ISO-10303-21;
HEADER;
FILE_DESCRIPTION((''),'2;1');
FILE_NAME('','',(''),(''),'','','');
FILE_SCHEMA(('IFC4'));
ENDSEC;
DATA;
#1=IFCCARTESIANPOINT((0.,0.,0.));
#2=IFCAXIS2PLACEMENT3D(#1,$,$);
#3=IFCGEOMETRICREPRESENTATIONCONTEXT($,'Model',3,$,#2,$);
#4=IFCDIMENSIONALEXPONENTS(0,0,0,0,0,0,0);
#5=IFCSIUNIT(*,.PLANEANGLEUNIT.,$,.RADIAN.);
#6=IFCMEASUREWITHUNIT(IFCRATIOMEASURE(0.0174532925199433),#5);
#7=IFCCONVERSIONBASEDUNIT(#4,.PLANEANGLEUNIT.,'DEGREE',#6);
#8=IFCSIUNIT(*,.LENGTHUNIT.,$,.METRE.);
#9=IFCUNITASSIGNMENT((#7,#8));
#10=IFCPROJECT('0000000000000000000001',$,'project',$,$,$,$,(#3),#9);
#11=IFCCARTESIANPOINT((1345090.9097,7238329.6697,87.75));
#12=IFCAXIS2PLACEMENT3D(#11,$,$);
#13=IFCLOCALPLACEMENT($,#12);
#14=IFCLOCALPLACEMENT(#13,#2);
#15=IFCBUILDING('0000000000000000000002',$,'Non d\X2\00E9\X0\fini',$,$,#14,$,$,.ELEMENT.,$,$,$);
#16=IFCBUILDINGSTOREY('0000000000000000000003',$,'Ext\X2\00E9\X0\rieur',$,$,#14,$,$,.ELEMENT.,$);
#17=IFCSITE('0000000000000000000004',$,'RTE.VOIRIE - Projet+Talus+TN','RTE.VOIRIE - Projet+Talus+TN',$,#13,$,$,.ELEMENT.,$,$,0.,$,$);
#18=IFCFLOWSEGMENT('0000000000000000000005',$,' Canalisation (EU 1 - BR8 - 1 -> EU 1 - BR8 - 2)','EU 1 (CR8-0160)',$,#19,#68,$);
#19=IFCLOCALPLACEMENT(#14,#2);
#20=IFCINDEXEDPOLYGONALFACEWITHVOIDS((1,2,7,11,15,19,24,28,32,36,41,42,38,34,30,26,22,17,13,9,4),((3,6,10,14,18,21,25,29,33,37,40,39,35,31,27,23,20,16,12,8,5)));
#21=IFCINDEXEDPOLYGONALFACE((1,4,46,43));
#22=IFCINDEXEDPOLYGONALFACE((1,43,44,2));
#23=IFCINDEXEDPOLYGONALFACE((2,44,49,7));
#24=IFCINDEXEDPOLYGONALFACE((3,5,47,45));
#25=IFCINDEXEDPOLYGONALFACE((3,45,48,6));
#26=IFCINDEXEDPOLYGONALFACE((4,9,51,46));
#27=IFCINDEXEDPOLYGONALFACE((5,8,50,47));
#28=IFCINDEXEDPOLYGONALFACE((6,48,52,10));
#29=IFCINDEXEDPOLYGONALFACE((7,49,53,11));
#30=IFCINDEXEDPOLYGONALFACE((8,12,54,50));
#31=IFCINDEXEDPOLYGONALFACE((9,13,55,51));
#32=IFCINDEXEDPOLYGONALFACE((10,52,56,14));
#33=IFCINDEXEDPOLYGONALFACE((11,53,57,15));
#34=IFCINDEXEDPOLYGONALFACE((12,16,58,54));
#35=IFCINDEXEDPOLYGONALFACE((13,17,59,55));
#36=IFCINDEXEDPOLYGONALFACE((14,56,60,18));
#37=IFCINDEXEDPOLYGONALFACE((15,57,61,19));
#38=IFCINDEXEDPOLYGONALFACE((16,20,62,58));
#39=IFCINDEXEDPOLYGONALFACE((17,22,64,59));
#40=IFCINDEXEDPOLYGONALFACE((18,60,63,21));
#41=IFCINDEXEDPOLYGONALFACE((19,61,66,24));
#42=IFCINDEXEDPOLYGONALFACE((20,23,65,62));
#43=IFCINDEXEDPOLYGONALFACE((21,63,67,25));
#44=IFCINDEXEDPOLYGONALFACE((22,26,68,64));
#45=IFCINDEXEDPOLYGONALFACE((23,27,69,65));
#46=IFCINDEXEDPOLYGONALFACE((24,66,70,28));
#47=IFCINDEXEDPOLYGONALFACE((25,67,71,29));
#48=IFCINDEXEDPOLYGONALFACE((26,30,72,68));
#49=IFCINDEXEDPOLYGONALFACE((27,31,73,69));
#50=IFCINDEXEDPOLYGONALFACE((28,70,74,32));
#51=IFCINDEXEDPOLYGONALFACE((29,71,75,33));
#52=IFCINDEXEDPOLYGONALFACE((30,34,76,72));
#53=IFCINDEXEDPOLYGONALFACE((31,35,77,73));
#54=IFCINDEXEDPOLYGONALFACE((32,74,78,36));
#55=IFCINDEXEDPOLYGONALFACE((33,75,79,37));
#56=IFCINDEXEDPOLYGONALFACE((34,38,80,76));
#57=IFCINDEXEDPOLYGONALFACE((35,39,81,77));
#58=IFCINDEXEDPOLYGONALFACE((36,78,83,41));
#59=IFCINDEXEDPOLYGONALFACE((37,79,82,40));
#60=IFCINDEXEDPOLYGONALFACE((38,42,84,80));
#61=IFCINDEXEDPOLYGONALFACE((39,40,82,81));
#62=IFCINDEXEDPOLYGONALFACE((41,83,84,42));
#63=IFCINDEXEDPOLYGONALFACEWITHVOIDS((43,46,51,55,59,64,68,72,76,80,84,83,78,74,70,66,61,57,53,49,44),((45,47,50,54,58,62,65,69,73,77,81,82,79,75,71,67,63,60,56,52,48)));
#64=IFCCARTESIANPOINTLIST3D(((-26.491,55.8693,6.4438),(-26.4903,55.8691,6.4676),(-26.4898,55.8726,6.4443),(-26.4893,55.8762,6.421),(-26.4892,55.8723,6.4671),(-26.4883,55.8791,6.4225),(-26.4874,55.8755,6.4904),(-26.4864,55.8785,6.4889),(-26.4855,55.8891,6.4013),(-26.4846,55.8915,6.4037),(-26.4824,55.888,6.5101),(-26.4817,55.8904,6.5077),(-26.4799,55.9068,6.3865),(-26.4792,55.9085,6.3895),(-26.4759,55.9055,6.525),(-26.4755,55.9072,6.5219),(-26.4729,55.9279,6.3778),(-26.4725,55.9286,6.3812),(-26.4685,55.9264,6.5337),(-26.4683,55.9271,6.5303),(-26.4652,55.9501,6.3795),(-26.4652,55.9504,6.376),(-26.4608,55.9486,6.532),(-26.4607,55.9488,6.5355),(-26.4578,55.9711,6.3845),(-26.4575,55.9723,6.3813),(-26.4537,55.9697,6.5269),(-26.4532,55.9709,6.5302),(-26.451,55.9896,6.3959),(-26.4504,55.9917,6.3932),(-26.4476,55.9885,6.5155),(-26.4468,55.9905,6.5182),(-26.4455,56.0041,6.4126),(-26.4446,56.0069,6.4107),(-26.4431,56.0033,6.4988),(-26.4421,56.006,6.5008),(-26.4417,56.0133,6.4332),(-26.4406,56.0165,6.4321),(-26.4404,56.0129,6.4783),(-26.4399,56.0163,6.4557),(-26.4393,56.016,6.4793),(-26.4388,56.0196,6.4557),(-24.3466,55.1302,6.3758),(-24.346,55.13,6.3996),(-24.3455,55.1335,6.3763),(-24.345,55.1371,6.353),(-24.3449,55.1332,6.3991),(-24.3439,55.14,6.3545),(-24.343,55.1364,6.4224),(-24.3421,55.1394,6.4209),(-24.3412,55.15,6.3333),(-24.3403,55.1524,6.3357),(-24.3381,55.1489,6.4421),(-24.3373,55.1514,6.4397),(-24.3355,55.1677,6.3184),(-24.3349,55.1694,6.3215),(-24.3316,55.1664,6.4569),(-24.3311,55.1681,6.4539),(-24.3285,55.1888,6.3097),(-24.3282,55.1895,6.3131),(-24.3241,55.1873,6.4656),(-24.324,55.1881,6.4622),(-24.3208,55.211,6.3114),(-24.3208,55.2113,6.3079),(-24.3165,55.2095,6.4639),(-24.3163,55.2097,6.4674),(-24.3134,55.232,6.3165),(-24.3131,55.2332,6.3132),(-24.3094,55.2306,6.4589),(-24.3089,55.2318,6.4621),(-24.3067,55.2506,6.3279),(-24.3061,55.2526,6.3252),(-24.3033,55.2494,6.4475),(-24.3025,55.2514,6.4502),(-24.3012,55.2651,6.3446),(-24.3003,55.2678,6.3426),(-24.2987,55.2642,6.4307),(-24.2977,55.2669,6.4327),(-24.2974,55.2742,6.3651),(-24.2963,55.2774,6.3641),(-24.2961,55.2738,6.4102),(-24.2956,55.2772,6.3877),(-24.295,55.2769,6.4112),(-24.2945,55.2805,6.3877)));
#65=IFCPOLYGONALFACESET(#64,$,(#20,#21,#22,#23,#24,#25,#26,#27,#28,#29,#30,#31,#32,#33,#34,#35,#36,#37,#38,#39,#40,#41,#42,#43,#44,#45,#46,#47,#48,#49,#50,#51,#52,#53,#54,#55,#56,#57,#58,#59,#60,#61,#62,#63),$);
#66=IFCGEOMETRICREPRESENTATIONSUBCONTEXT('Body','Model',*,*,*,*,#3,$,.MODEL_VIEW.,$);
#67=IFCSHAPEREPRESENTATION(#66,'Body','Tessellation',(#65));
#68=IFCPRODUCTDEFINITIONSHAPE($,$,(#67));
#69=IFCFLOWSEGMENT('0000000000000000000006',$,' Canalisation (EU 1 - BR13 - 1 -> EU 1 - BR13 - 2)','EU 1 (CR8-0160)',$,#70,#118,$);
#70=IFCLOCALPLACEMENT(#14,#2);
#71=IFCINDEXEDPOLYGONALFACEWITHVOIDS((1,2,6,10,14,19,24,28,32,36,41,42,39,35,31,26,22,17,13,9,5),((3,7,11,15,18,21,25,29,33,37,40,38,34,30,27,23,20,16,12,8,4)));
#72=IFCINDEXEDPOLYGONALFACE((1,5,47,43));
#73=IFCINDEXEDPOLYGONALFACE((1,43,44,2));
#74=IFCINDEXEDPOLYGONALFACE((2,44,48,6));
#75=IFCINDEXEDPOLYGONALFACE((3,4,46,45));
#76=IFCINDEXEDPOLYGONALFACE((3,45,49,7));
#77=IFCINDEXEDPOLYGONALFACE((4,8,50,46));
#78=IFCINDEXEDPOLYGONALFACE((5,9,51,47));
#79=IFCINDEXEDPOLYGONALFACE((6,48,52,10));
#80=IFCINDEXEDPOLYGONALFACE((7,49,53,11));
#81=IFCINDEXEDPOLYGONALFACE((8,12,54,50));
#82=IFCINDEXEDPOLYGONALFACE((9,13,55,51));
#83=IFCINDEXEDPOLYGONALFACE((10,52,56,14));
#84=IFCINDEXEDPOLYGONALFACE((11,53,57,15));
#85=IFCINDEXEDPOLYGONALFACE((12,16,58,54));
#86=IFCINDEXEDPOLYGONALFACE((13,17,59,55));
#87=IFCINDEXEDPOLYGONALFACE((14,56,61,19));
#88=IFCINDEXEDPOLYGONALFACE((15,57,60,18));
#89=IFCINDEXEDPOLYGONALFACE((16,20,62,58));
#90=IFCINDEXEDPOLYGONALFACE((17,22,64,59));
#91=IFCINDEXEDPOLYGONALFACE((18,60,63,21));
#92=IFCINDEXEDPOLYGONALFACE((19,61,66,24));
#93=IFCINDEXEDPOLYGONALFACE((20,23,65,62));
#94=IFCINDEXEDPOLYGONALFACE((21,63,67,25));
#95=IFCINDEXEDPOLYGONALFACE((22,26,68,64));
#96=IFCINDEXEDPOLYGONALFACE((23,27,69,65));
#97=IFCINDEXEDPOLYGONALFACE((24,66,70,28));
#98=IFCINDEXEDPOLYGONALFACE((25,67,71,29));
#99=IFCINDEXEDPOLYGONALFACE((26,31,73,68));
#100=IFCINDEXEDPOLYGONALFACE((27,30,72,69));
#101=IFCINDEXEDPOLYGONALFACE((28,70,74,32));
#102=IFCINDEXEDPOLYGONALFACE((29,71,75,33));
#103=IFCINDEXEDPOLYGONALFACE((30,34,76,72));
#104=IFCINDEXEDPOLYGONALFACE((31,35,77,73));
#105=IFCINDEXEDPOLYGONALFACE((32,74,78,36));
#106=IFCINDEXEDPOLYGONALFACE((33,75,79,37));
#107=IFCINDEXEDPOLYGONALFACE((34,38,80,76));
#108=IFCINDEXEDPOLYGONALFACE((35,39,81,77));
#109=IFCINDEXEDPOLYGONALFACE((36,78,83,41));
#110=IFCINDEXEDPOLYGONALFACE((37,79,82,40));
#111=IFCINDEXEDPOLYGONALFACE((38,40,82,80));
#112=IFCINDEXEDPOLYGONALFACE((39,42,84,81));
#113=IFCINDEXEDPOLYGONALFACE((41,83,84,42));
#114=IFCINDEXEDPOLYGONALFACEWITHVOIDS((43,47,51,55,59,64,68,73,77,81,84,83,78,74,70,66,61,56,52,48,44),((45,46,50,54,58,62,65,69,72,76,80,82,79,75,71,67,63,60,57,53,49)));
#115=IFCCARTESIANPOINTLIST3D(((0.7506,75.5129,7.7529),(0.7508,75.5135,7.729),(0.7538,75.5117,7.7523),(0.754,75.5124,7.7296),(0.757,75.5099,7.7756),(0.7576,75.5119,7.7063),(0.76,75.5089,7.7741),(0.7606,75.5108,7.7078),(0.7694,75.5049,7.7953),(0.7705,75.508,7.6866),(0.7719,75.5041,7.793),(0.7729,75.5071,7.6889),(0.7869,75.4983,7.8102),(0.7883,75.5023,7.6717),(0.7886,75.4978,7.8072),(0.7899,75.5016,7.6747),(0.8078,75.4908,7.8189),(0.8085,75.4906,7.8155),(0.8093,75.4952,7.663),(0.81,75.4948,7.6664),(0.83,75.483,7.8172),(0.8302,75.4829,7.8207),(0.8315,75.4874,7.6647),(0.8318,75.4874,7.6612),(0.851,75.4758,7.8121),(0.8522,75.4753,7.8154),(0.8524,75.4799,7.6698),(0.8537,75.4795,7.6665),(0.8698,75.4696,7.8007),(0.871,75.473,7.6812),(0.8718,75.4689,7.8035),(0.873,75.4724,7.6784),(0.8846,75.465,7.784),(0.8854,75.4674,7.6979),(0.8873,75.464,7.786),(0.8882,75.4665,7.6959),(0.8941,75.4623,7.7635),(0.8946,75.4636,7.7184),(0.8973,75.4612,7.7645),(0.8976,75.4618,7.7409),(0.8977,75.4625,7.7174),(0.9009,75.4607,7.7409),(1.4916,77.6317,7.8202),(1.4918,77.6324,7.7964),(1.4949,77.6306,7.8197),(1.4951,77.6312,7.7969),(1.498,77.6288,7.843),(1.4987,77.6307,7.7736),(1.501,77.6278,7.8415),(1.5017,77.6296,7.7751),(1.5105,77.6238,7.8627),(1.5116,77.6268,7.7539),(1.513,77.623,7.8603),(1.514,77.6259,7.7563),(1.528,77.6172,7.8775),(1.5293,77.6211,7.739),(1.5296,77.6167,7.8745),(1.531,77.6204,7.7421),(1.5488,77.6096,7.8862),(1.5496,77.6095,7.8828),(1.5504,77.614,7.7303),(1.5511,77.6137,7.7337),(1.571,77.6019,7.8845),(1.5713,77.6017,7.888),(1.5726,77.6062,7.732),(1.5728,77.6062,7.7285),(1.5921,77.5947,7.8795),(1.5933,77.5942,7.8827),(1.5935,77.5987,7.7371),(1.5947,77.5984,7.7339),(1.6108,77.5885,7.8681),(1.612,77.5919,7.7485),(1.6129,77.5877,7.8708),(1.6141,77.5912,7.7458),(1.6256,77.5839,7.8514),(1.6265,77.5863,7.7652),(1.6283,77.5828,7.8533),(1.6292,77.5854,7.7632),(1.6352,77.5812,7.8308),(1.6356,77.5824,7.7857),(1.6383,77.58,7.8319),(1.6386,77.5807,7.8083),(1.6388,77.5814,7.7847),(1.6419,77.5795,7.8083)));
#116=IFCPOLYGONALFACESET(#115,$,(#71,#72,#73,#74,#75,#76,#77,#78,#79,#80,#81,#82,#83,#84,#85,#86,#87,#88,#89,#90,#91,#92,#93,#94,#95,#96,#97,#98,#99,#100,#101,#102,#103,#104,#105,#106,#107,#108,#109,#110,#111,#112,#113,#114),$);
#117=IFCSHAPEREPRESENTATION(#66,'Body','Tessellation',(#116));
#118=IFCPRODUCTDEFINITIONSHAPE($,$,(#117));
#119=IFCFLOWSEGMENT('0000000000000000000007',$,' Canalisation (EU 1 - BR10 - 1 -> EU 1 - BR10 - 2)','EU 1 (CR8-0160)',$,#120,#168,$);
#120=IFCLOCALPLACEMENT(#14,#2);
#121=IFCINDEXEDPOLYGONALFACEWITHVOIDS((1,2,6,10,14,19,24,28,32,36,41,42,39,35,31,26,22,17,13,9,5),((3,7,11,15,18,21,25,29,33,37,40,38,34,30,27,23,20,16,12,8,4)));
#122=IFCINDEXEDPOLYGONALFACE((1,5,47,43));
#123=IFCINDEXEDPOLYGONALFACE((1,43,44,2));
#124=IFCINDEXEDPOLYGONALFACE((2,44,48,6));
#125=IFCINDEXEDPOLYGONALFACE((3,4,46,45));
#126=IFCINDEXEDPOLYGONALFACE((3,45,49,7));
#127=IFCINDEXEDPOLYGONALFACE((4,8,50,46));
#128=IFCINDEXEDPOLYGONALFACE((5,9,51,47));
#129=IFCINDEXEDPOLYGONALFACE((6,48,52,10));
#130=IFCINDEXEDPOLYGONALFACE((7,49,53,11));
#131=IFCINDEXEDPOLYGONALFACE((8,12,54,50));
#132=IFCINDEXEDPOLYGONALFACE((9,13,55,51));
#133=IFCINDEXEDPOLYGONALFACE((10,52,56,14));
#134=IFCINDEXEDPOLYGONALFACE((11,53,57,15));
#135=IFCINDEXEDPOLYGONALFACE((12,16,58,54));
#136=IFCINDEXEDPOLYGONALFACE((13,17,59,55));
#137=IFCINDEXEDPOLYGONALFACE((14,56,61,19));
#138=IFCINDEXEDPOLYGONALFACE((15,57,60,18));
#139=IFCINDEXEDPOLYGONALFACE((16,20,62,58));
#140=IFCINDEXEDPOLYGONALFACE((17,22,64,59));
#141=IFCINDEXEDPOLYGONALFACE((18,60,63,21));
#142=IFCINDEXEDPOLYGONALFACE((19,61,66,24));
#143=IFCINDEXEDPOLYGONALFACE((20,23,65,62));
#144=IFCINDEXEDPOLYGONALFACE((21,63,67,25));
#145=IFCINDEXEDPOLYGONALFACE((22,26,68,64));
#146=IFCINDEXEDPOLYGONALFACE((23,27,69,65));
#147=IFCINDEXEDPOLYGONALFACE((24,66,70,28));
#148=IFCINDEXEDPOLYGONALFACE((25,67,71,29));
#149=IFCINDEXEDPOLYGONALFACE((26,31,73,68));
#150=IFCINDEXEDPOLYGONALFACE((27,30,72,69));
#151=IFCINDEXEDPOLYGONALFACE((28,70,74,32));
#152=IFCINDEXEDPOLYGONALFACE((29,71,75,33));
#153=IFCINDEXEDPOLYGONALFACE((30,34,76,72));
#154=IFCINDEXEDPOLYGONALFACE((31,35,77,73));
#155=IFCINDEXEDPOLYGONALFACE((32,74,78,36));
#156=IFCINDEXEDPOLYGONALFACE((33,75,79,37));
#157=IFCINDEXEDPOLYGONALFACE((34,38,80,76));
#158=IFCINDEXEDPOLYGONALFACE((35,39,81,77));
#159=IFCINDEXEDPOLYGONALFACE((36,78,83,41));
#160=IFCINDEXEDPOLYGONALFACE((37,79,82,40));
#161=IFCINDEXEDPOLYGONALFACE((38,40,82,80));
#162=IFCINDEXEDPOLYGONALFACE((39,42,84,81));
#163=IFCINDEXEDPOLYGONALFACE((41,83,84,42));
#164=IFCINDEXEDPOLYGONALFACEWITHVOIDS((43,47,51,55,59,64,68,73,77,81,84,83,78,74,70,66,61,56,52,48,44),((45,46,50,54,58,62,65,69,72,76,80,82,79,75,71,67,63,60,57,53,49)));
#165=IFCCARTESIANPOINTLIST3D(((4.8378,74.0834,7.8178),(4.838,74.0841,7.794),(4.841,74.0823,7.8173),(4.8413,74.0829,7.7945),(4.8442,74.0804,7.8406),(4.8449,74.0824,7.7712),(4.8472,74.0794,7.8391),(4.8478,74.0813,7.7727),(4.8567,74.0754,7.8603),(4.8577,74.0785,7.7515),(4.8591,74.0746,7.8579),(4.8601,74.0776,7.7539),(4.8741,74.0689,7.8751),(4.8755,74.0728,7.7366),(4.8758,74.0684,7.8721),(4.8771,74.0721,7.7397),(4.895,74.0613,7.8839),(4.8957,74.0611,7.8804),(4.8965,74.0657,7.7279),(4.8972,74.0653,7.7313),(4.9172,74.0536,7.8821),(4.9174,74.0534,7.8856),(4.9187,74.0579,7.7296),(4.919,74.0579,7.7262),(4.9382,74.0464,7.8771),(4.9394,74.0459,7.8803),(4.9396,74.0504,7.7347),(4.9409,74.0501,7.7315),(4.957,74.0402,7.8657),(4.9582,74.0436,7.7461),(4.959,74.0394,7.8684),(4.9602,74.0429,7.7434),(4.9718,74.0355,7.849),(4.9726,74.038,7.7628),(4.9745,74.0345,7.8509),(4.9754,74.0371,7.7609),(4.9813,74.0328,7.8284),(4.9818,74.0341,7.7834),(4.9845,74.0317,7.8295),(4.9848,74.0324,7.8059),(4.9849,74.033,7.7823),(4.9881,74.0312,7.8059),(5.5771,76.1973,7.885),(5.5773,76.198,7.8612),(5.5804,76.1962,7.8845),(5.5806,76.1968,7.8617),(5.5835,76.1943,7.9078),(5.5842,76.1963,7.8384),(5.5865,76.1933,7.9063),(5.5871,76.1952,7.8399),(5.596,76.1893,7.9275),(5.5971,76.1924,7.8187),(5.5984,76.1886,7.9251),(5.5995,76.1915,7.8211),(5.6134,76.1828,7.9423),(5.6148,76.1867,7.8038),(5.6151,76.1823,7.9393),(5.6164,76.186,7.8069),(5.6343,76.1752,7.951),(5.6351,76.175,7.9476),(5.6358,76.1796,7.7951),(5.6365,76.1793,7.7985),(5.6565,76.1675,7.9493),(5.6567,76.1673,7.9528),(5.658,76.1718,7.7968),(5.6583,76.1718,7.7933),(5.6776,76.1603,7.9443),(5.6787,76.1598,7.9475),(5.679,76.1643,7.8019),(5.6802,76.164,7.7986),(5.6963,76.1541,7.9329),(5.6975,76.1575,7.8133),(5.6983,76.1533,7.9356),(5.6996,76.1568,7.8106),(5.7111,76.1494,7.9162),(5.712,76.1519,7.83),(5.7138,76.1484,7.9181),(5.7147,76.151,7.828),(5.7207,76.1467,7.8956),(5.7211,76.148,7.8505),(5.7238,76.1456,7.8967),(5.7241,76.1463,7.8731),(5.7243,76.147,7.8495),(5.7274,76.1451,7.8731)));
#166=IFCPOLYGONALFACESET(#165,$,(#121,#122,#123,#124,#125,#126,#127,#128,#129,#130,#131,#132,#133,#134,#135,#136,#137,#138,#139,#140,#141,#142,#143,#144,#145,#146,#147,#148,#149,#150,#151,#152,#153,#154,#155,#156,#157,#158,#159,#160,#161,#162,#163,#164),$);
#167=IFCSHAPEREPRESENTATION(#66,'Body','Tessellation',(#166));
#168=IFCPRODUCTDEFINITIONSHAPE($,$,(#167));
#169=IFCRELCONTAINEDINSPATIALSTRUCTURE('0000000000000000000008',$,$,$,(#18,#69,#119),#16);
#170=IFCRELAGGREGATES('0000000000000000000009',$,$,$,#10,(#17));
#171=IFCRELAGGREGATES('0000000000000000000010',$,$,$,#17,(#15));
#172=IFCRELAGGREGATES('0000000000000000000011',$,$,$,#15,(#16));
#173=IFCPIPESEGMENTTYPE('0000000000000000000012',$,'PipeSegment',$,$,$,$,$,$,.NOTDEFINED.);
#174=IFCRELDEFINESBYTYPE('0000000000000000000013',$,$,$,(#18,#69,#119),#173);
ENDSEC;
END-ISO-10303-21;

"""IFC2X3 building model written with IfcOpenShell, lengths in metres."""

from ifc_helpers import new_model, entity, si_unit, converted_unit, frame, origin, origin_2d_with_axis, place, context, subcontext, project, spatial, hollow_circle, extrude, type_object, element, save


model = new_model("IFC2X3")

# Units and contexts
model_context = context("Model", 3, world=origin())
body_context = subcontext(model_context, "Body", "Model", "MODEL_VIEW")
ifc_project = project(units=[converted_unit("PLANEANGLEUNIT", "DEGREE", entity("IfcRatioMeasure", 0.0174532925199433), si_unit("PLANEANGLEUNIT", "RADIAN"), dimensions=[0, 0, 0, 0, 0, 0, 0]), si_unit("LENGTHUNIT", "METRE")], contexts=[model_context])

# Site, building, storey
site_placement = place(None, frame((1345090.9097, 7238329.6697, 87.75)))
site = spatial("IfcSite", under=ifc_project, at=site_placement, Name="RTE.VOIRIE - Projet+Talus+TN", Description="RTE.VOIRIE - Projet+Talus+TN", CompositionType="ELEMENT", RefElevation=0.0)
placement = place(site_placement, origin())
building = spatial("IfcBuilding", under=site, at=placement, Name="Non défini", CompositionType="ELEMENT")
storey = spatial("IfcBuildingStorey", under=building, at=placement, Name="Extérieur", CompositionType="ELEMENT")

# Flow segments
pipe_segment_type_1 = type_object("IfcPipeSegmentType", Name="PipeSegment", PredefinedType="NOTDEFINED")
flow_segment_1_placement = place(placement, origin())
element("IfcFlowSegment", 1, at=flow_segment_1_placement, inside=storey, type_object=pipe_segment_type_1, Name=" Canalisation (EU 1 - BR8 - 1 -> EU 1 - BR8 - 2)", Description="EU 1 (CR8-0160)", context=body_context, shape_type="SweptSolid", body=[
    extrude(hollow_circle(Radius=0.08, WallThickness=0.0035, at=origin_2d_with_axis()), frame((-26.4649, 55.944, 6.4557), z_axis=(0.944994, -0.32571, -0.029987), x_axis=(0.32571, 0.944994, 0.0)), (0.0, 0.0, 1.0), 2.2692),
])
flow_segment_2_placement = place(placement, origin())
element("IfcFlowSegment", 2, at=flow_segment_2_placement, inside=storey, type_object=pipe_segment_type_1, Name=" Canalisation (EU 1 - BR13 - 1 -> EU 1 - BR13 - 2)", Description="EU 1 (CR8-0160)", context=body_context, shape_type="SweptSolid", body=[
    extrude(hollow_circle(Radius=0.08, WallThickness=0.0035, at=origin_2d_with_axis()), frame((1.5664, 77.6059, 7.8083), z_axis=(-0.329987, -0.943509, -0.029987), x_axis=(0.943509, -0.329987, 0.0)), (0.0, 0.0, 1.0), 2.2457),
])
flow_segment_3_placement = place(placement, origin())
element("IfcFlowSegment", 3, at=flow_segment_3_placement, inside=storey, type_object=pipe_segment_type_1, Name=" Canalisation (EU 1 - BR10 - 1 -> EU 1 - BR10 - 2)", Description="EU 1 (CR8-0160)", context=body_context, shape_type="SweptSolid", body=[
    extrude(hollow_circle(Radius=0.08, WallThickness=0.0035, at=origin_2d_with_axis()), frame((5.6519, 76.1715, 7.8731), z_axis=(-0.329987, -0.943509, -0.029987), x_axis=(0.943509, -0.329987, 0.0)), (0.0, 0.0, 1.0), 2.2405),
])

save(model, "model.ifc")
